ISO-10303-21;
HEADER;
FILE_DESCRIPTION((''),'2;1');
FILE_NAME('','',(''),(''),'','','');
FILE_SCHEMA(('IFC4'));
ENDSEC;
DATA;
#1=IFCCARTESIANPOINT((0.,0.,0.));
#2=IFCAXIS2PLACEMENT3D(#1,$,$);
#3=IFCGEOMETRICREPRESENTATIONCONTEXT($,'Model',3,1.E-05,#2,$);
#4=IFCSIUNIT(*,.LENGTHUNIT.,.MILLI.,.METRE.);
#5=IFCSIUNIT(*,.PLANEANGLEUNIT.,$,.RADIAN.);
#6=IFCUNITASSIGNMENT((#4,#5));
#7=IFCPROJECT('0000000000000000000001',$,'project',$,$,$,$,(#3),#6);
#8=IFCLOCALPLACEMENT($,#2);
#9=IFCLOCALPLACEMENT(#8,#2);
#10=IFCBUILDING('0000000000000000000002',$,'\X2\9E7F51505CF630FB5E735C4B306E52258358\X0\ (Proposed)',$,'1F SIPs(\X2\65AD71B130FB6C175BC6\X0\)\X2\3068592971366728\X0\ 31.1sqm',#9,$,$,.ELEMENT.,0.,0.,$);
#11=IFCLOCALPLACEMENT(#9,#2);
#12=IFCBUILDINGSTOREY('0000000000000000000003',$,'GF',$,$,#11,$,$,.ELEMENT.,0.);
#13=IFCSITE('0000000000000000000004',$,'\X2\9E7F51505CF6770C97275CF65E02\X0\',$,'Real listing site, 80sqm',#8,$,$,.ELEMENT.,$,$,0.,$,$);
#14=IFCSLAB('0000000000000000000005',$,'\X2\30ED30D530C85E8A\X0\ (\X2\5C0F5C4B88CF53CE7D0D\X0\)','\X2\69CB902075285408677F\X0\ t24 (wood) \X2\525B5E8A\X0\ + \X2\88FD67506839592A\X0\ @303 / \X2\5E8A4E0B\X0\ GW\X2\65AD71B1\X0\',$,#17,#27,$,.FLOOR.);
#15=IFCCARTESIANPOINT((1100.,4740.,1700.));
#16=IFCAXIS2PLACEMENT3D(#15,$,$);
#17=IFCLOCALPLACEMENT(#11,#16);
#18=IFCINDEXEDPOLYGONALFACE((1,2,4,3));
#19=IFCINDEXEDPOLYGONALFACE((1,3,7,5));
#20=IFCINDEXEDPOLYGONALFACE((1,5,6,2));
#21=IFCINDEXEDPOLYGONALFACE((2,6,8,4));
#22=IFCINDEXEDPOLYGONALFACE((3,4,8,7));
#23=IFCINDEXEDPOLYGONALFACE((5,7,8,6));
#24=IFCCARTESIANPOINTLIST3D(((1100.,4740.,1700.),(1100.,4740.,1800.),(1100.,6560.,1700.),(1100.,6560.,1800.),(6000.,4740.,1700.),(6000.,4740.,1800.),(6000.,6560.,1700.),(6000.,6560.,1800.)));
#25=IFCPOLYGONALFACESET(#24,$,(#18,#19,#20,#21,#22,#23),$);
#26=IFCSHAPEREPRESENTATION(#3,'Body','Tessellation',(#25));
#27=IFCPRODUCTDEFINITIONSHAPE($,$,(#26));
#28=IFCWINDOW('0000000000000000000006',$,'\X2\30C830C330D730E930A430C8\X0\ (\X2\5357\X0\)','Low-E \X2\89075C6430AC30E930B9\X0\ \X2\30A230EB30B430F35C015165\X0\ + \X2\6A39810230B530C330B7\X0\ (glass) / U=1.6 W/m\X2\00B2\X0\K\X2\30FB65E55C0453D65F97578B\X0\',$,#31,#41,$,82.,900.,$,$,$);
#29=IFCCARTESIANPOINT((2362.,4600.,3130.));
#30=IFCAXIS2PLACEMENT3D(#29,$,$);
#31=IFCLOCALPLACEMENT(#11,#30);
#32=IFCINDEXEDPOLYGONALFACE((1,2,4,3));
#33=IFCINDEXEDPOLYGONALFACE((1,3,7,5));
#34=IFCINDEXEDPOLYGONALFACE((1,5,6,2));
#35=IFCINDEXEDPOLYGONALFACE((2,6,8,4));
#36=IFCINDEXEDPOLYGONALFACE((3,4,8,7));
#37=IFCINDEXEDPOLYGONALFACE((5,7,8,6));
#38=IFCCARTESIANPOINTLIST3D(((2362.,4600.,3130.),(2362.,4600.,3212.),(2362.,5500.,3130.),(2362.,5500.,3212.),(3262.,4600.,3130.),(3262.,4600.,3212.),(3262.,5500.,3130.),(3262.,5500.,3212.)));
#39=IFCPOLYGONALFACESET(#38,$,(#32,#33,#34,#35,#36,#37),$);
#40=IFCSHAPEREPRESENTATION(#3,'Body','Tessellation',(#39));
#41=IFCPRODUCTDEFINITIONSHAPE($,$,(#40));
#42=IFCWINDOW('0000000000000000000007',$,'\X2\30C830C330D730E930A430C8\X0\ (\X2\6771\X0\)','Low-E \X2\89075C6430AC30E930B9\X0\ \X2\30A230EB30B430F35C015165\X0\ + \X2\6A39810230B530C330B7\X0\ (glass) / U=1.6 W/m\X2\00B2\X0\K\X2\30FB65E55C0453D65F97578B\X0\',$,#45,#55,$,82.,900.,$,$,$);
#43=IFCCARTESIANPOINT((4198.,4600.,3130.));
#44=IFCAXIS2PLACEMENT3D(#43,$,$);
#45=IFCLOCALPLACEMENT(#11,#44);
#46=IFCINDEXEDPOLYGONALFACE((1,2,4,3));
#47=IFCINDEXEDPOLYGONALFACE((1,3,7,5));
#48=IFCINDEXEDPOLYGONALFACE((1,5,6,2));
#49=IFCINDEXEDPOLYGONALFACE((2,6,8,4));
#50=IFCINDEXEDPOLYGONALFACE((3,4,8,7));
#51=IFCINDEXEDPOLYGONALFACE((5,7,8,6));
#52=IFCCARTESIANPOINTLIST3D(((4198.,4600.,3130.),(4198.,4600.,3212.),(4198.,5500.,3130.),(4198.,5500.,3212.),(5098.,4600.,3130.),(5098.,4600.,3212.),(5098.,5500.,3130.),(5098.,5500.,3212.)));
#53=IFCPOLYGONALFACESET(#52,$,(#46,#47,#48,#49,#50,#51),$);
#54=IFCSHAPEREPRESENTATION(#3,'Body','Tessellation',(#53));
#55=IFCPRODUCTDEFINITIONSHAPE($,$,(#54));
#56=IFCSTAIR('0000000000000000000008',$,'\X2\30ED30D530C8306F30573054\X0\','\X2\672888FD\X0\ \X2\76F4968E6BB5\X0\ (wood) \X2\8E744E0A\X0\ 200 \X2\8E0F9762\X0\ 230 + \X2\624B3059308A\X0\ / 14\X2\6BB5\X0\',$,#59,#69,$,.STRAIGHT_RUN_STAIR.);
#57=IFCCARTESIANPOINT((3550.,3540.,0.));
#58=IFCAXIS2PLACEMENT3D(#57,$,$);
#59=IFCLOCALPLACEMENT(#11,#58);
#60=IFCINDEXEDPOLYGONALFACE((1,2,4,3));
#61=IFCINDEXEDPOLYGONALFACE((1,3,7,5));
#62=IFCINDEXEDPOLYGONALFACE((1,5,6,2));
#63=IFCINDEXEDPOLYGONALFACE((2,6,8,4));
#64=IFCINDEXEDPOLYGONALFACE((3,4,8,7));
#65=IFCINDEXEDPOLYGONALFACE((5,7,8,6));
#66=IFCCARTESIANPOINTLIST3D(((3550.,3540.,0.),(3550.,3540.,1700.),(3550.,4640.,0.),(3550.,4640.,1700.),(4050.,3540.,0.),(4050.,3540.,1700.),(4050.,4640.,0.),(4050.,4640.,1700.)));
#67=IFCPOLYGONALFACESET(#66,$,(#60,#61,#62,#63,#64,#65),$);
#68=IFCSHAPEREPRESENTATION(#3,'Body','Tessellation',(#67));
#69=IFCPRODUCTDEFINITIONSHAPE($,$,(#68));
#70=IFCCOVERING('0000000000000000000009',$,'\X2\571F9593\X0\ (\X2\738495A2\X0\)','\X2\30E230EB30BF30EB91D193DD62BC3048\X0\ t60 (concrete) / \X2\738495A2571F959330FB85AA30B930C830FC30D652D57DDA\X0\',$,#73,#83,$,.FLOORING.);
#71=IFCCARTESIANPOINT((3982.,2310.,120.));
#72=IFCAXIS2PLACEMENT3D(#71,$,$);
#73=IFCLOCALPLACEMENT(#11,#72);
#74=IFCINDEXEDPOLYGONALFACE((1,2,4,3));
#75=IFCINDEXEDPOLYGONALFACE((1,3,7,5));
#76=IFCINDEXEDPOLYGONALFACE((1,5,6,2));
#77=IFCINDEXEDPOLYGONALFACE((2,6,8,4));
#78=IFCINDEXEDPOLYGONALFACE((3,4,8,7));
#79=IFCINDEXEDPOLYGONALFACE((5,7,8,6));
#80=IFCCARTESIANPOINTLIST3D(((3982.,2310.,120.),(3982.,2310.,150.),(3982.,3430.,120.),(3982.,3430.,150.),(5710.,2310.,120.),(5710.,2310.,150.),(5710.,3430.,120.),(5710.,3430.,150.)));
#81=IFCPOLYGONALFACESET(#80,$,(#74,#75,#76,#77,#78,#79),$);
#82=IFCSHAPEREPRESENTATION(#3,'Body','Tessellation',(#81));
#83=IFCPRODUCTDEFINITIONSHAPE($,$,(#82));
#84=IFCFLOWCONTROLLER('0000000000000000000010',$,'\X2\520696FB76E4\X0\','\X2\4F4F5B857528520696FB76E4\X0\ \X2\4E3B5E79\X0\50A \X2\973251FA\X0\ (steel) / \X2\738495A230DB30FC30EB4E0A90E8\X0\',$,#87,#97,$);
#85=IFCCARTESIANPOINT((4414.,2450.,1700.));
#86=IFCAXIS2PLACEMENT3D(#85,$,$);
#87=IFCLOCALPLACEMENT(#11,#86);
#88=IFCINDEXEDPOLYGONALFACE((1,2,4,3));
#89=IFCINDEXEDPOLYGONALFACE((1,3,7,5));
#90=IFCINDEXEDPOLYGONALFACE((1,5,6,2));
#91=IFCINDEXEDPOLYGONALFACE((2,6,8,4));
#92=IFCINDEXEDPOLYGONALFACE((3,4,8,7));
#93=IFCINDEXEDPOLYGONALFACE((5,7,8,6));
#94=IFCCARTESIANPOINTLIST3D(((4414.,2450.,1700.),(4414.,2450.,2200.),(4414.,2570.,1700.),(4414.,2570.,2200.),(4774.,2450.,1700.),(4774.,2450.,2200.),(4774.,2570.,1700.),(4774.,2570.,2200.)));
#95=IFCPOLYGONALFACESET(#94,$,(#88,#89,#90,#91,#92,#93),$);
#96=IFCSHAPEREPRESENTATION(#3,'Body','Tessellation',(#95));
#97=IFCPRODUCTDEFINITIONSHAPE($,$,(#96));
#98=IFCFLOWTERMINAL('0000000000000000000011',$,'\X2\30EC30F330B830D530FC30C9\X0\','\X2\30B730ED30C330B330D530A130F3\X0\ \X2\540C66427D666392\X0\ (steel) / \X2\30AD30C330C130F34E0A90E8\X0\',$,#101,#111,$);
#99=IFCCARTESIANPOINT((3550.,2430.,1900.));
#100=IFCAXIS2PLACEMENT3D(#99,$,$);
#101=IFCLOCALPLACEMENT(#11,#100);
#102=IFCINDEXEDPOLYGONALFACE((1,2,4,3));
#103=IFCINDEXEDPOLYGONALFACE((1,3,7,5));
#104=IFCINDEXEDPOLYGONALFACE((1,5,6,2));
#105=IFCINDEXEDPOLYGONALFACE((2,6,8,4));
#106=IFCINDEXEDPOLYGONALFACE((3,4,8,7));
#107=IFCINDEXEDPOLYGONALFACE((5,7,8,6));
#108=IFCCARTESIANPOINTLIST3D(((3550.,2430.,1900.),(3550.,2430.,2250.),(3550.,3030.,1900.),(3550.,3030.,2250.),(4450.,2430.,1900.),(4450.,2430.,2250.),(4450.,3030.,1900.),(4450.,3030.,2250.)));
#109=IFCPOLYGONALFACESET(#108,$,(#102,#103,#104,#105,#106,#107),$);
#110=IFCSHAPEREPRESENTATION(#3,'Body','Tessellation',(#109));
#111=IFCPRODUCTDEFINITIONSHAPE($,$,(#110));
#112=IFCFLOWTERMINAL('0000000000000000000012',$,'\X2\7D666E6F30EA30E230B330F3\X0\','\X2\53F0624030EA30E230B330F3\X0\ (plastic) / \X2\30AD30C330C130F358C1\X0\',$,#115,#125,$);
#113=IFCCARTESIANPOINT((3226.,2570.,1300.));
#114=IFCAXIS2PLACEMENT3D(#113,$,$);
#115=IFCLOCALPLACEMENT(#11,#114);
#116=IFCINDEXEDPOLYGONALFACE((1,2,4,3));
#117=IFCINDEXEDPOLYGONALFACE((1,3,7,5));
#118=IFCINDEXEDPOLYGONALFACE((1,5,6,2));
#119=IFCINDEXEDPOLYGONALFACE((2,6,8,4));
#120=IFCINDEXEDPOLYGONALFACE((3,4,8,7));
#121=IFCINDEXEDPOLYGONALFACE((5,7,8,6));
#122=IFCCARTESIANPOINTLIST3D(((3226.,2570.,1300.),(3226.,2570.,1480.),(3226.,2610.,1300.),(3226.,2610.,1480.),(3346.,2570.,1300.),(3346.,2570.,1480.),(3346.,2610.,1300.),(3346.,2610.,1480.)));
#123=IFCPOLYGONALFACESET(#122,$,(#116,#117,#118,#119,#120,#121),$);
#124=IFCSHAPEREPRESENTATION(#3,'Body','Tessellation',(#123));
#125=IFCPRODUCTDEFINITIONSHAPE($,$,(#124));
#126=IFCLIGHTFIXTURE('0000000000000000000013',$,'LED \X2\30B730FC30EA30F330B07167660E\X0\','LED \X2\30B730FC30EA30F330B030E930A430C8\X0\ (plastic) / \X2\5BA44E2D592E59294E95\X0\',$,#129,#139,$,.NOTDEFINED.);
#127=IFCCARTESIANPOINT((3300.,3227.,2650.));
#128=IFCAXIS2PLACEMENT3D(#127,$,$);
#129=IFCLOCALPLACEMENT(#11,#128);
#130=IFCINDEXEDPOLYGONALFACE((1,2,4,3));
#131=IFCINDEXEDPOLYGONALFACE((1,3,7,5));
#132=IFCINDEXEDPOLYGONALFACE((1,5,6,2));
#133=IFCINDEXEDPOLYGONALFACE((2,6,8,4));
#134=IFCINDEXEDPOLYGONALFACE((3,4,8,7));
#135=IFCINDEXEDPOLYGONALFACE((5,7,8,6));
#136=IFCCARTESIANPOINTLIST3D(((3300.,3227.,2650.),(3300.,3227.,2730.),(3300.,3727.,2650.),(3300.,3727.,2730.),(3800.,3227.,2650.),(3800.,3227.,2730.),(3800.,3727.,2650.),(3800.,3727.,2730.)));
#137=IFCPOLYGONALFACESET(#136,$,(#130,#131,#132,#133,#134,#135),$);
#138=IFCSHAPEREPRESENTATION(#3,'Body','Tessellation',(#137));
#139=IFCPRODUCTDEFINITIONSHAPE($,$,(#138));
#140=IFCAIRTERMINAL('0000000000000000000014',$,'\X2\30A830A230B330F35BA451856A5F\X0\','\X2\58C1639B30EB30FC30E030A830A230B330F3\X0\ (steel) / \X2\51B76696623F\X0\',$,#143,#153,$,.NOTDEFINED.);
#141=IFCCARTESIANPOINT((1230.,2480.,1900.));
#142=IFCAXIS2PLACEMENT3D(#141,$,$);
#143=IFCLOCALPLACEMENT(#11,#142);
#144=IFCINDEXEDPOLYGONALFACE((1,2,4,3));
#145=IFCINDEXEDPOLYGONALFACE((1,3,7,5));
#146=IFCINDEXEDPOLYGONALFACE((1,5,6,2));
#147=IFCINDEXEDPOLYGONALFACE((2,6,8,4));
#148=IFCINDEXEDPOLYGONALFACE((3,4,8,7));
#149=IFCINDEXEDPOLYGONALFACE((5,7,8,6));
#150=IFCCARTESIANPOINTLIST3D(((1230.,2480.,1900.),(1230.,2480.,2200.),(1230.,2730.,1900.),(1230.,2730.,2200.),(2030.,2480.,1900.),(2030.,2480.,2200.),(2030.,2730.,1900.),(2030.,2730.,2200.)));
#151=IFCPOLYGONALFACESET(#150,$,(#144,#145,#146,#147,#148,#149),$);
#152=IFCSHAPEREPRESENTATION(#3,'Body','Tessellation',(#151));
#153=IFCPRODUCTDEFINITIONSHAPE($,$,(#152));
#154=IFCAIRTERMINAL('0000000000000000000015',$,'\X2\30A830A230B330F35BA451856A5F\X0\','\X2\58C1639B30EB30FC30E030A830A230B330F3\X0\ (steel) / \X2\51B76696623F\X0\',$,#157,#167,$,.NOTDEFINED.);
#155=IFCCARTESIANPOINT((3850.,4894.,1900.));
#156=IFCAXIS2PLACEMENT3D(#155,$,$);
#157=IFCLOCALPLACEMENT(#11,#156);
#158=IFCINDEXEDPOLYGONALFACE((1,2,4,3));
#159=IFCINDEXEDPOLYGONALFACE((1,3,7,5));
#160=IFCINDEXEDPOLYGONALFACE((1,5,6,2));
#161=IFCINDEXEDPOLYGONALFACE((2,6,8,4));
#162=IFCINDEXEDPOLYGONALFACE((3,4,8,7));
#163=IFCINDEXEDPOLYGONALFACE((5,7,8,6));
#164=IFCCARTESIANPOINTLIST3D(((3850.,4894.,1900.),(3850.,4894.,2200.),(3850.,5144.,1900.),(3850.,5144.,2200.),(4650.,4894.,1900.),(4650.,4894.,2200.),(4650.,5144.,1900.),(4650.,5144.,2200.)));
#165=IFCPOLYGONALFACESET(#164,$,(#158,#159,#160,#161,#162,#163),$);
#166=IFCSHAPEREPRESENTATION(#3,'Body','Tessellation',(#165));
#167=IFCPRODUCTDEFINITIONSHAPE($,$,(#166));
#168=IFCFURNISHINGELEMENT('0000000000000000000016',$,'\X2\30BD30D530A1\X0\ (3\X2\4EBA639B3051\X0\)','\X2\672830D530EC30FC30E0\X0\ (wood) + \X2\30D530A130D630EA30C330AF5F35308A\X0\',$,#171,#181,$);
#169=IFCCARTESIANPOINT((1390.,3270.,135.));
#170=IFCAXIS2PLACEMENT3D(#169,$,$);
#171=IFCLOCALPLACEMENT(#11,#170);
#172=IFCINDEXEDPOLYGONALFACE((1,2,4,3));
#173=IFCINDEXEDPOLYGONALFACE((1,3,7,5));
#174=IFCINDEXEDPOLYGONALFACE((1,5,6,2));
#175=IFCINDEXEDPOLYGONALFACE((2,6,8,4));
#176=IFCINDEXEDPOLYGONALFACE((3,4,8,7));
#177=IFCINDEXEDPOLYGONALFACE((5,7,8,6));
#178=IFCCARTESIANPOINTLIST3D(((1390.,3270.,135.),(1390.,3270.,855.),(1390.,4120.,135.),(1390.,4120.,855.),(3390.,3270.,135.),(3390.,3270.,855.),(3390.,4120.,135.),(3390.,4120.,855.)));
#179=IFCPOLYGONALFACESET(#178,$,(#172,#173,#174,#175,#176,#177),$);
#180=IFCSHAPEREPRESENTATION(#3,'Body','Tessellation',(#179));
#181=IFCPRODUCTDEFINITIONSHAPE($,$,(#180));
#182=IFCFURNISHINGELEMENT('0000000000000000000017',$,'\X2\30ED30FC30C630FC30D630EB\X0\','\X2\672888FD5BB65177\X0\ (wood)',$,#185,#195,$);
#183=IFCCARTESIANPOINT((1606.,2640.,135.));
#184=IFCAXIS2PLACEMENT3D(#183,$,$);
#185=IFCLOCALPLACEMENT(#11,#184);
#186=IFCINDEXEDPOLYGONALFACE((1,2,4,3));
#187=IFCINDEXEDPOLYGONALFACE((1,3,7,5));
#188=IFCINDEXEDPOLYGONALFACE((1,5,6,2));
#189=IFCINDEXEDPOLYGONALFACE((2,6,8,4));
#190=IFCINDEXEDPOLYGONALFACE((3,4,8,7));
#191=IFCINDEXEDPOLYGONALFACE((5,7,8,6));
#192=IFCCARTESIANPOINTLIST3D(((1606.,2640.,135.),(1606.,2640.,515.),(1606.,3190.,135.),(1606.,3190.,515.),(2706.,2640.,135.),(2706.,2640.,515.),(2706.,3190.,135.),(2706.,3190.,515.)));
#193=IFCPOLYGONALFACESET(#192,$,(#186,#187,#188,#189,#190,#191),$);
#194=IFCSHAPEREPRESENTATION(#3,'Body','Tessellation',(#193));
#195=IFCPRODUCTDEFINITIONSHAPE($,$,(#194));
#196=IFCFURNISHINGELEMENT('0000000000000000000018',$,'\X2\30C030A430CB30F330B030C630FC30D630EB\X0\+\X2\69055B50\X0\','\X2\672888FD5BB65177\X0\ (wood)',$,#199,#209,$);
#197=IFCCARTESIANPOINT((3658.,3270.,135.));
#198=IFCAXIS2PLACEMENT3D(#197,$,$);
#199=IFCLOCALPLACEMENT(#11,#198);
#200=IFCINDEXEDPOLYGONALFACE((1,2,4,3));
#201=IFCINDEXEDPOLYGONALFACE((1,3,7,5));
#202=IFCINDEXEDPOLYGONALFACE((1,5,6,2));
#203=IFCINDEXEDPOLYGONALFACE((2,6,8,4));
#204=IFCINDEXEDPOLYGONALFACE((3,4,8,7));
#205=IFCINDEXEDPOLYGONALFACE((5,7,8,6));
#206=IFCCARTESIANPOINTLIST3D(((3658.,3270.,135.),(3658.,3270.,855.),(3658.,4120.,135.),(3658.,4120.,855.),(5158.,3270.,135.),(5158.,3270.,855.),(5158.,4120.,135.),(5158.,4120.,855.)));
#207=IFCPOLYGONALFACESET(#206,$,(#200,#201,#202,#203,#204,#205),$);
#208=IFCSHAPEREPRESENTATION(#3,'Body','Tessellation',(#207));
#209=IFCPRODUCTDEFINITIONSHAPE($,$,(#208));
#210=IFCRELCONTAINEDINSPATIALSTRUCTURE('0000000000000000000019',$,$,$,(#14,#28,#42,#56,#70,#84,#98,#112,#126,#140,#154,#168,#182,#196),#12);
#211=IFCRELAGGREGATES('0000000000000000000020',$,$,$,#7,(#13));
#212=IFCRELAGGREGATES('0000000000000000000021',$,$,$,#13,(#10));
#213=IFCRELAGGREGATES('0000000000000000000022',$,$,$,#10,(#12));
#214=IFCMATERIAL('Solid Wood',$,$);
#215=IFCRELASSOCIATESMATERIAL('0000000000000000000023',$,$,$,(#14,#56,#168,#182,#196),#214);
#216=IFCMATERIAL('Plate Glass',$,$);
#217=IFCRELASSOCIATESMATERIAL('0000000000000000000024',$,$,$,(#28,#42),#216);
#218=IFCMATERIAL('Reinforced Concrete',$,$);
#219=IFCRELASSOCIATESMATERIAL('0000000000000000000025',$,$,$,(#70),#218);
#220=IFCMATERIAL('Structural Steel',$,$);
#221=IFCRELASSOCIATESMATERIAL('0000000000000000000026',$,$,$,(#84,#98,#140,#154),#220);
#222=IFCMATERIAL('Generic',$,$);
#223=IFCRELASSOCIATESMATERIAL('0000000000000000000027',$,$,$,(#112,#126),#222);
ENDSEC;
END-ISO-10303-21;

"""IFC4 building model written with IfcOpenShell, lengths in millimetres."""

from ifc_helpers import new_model, si_unit, frame, frame_2d, origin, place, context, project, spatial, rectangle, extrude, material, element, save


model = new_model("IFC4")

# Units and contexts
model_context = context("Model", 3, precision=1e-05, world=origin())
ifc_project = project(units=[si_unit("LENGTHUNIT", "METRE", prefix="MILLI"), si_unit("PLANEANGLEUNIT", "RADIAN")], contexts=[model_context])

# Site, building, storey
site_placement = place(None, origin())
site = spatial("IfcSite", under=ifc_project, at=site_placement, Name="鹿児島県霧島市", ObjectType="Real listing site, 80sqm", CompositionType="ELEMENT", RefElevation=0.0)
building_placement = place(site_placement, origin())
building = spatial("IfcBuilding", under=site, at=building_placement, Name="鹿児島・平屋の別荘 (Proposed)", ObjectType="1F SIPs(断熱・気密)と天然木 31.1sqm", CompositionType="ELEMENT", ElevationOfRefHeight=0.0, ElevationOfTerrain=0.0)
storey_placement = place(building_placement, origin())
storey = spatial("IfcBuildingStorey", under=building, at=storey_placement, Name="GF", CompositionType="ELEMENT", Elevation=0.0)

# Shared definitions
ifc_material_1 = material(Name="Solid Wood")

# Slab
slab_placement = place(storey_placement, frame((1100.0, 4740.0, 1700.0)))
element("IfcSlab", 1, at=slab_placement, inside=storey, material=ifc_material_1, Name="ロフト床 (小屋裏収納)", Description="構造用合板 t24 (wood) 剛床 + 製材根太 @303 / 床下 GW断熱", PredefinedType="FLOOR", context=model_context, shape_type="SweptSolid", body=[
    extrude(rectangle(XDim=4900.0, YDim=1820.0, at=frame_2d((2450.0, 910.0))), frame((1100.0, 4740.0, 1700.0)), (0.0, 0.0, 1.0), 100.0),
])

# Windows
ifc_material_2 = material(Name="Plate Glass")
window_1_placement = place(storey_placement, frame((2362.0, 4600.0, 3130.0)))
element("IfcWindow", 2, at=window_1_placement, inside=storey, material=ifc_material_2, Name="トップライト (南)", Description="Low-E 複層ガラス アルゴン封入 + 樹脂サッシ (glass) / U=1.6 W/m²K・日射取得型", OverallHeight=82.0, OverallWidth=900.0, context=model_context, shape_type="SweptSolid", body=[
    extrude(rectangle(XDim=900.0, YDim=900.0, at=frame_2d((450.0, 450.0))), frame((2362.0, 4600.0, 3130.0)), (0.0, 0.0, 1.0), 82.0),
])
window_2_placement = place(storey_placement, frame((4198.0, 4600.0, 3130.0)))
element("IfcWindow", 3, at=window_2_placement, inside=storey, material=ifc_material_2, Name="トップライト (東)", Description="Low-E 複層ガラス アルゴン封入 + 樹脂サッシ (glass) / U=1.6 W/m²K・日射取得型", OverallHeight=82.0, OverallWidth=900.0, context=model_context, shape_type="SweptSolid", body=[
    extrude(rectangle(XDim=900.0, YDim=900.0, at=frame_2d((450.0, 450.0))), frame((4198.0, 4600.0, 3130.0)), (0.0, 0.0, 1.0), 82.0),
])

# Stair
stair_placement = place(storey_placement, frame((3550.0, 3540.0, 0.0)))
element("IfcStair", 4, at=stair_placement, inside=storey, material=ifc_material_1, Name="ロフトはしご", Description="木製 直階段 (wood) 蹴上 200 踏面 230 + 手すり / 14段", PredefinedType="STRAIGHT_RUN_STAIR", context=model_context, shape_type="SweptSolid", body=[
    extrude(rectangle(XDim=500.0, YDim=1100.0, at=frame_2d((250.0, 550.0))), frame((3550.0, 3540.0, 0.0)), (0.0, 0.0, 1.0), 1700.0),
])

# Covering
ifc_material_3 = material(Name="Reinforced Concrete")
covering_placement = place(storey_placement, frame((3982.0, 2310.0, 120.0)))
element("IfcCovering", 5, at=covering_placement, inside=storey, material=ifc_material_3, Name="土間 (玄関)", Description="モルタル金鏝押え t60 (concrete) / 玄関土間・薪ストーブ動線", PredefinedType="FLOORING", context=model_context, shape_type="SweptSolid", body=[
    extrude(rectangle(XDim=1728.0, YDim=1120.0, at=frame_2d((864.0, 560.0))), frame((3982.0, 2310.0, 120.0)), (0.0, 0.0, 1.0), 30.0),
])

# Flow controller
ifc_material_4 = material(Name="Structural Steel")
flow_controller_placement = place(storey_placement, frame((4414.0, 2450.0, 1700.0)))
element("IfcFlowController", 6, at=flow_controller_placement, inside=storey, material=ifc_material_4, Name="分電盤", Description="住宅用分電盤 主幹50A 露出 (steel) / 玄関ホール上部", context=model_context, shape_type="SweptSolid", body=[
    extrude(rectangle(XDim=360.0, YDim=120.0, at=frame_2d((180.0, 60.0))), frame((4414.0, 2450.0, 1700.0)), (0.0, 0.0, 1.0), 500.0),
])

# Flow terminals
flow_terminal_1_placement = place(storey_placement, frame((3550.0, 2430.0, 1900.0)))
element("IfcFlowTerminal", 7, at=flow_terminal_1_placement, inside=storey, material=ifc_material_4, Name="レンジフード", Description="シロッコファン 同時給排 (steel) / キッチン上部", context=model_context, shape_type="SweptSolid", body=[
    extrude(rectangle(XDim=900.0, YDim=600.0, at=frame_2d((450.0, 300.0))), frame((3550.0, 2430.0, 1900.0)), (0.0, 0.0, 1.0), 350.0),
])
ifc_material_5 = material(Name="Generic")
flow_terminal_2_placement = place(storey_placement, frame((3226.0, 2570.0, 1300.0)))
element("IfcFlowTerminal", 8, at=flow_terminal_2_placement, inside=storey, material=ifc_material_5, Name="給湯リモコン", Description="台所リモコン (plastic) / キッチン壁", context=model_context, shape_type="SweptSolid", body=[
    extrude(rectangle(XDim=120.0, YDim=40.0, at=frame_2d((60.0, 20.0))), frame((3226.0, 2570.0, 1300.0)), (0.0, 0.0, 1.0), 180.0),
])

# Light fixture
light_fixture_placement = place(storey_placement, frame((3300.0, 3227.0, 2650.0)))
element("IfcLightFixture", 9, at=light_fixture_placement, inside=storey, material=ifc_material_5, Name="LED シーリング照明", Description="LED シーリングライト (plastic) / 室中央天井", PredefinedType="NOTDEFINED", context=model_context, shape_type="SweptSolid", body=[
    extrude(rectangle(XDim=500.0, YDim=500.0, at=frame_2d((250.0, 250.0))), frame((3300.0, 3227.0, 2650.0)), (0.0, 0.0, 1.0), 80.0),
])

# Air terminals
air_terminal_1_placement = place(storey_placement, frame((1230.0, 2480.0, 1900.0)))
element("IfcAirTerminal", 10, at=air_terminal_1_placement, inside=storey, material=ifc_material_4, Name="エアコン室内機", Description="壁掛ルームエアコン (steel) / 冷暖房", PredefinedType="NOTDEFINED", context=model_context, shape_type="SweptSolid", body=[
    extrude(rectangle(XDim=800.0, YDim=250.0, at=frame_2d((400.0, 125.0))), frame((1230.0, 2480.0, 1900.0)), (0.0, 0.0, 1.0), 300.0),
])
air_terminal_2_placement = place(storey_placement, frame((3850.0, 4894.0, 1900.0)))
element("IfcAirTerminal", 11, at=air_terminal_2_placement, inside=storey, material=ifc_material_4, Name="エアコン室内機", Description="壁掛ルームエアコン (steel) / 冷暖房", PredefinedType="NOTDEFINED", context=model_context, shape_type="SweptSolid", body=[
    extrude(rectangle(XDim=800.0, YDim=250.0, at=frame_2d((400.0, 125.0))), frame((3850.0, 4894.0, 1900.0)), (0.0, 0.0, 1.0), 300.0),
])

# Furnishing elements
furnishing_1_placement = place(storey_placement, frame((1390.0, 3270.0, 135.0)))
element("IfcFurnishingElement", 12, at=furnishing_1_placement, inside=storey, material=ifc_material_1, Name="ソファ (3人掛け)", Description="木フレーム (wood) + ファブリック張り", context=model_context, shape_type="SweptSolid", body=[
    extrude(rectangle(XDim=2000.0, YDim=850.0, at=frame_2d((1000.0, 425.0))), frame((1390.0, 3270.0, 135.0)), (0.0, 0.0, 1.0), 720.0),
])
furnishing_2_placement = place(storey_placement, frame((1606.0, 2640.0, 135.0)))
element("IfcFurnishingElement", 13, at=furnishing_2_placement, inside=storey, material=ifc_material_1, Name="ローテーブル", Description="木製家具 (wood)", context=model_context, shape_type="SweptSolid", body=[
    extrude(rectangle(XDim=1100.0, YDim=550.0, at=frame_2d((550.0, 275.0))), frame((1606.0, 2640.0, 135.0)), (0.0, 0.0, 1.0), 380.0),
])
furnishing_3_placement = place(storey_placement, frame((3658.0, 3270.0, 135.0)))
element("IfcFurnishingElement", 14, at=furnishing_3_placement, inside=storey, material=ifc_material_1, Name="ダイニングテーブル+椅子", Description="木製家具 (wood)", context=model_context, shape_type="SweptSolid", body=[
    extrude(rectangle(XDim=1500.0, YDim=850.0, at=frame_2d((750.0, 425.0))), frame((3658.0, 3270.0, 135.0)), (0.0, 0.0, 1.0), 720.0),
])

save(model, "model.ifc")
